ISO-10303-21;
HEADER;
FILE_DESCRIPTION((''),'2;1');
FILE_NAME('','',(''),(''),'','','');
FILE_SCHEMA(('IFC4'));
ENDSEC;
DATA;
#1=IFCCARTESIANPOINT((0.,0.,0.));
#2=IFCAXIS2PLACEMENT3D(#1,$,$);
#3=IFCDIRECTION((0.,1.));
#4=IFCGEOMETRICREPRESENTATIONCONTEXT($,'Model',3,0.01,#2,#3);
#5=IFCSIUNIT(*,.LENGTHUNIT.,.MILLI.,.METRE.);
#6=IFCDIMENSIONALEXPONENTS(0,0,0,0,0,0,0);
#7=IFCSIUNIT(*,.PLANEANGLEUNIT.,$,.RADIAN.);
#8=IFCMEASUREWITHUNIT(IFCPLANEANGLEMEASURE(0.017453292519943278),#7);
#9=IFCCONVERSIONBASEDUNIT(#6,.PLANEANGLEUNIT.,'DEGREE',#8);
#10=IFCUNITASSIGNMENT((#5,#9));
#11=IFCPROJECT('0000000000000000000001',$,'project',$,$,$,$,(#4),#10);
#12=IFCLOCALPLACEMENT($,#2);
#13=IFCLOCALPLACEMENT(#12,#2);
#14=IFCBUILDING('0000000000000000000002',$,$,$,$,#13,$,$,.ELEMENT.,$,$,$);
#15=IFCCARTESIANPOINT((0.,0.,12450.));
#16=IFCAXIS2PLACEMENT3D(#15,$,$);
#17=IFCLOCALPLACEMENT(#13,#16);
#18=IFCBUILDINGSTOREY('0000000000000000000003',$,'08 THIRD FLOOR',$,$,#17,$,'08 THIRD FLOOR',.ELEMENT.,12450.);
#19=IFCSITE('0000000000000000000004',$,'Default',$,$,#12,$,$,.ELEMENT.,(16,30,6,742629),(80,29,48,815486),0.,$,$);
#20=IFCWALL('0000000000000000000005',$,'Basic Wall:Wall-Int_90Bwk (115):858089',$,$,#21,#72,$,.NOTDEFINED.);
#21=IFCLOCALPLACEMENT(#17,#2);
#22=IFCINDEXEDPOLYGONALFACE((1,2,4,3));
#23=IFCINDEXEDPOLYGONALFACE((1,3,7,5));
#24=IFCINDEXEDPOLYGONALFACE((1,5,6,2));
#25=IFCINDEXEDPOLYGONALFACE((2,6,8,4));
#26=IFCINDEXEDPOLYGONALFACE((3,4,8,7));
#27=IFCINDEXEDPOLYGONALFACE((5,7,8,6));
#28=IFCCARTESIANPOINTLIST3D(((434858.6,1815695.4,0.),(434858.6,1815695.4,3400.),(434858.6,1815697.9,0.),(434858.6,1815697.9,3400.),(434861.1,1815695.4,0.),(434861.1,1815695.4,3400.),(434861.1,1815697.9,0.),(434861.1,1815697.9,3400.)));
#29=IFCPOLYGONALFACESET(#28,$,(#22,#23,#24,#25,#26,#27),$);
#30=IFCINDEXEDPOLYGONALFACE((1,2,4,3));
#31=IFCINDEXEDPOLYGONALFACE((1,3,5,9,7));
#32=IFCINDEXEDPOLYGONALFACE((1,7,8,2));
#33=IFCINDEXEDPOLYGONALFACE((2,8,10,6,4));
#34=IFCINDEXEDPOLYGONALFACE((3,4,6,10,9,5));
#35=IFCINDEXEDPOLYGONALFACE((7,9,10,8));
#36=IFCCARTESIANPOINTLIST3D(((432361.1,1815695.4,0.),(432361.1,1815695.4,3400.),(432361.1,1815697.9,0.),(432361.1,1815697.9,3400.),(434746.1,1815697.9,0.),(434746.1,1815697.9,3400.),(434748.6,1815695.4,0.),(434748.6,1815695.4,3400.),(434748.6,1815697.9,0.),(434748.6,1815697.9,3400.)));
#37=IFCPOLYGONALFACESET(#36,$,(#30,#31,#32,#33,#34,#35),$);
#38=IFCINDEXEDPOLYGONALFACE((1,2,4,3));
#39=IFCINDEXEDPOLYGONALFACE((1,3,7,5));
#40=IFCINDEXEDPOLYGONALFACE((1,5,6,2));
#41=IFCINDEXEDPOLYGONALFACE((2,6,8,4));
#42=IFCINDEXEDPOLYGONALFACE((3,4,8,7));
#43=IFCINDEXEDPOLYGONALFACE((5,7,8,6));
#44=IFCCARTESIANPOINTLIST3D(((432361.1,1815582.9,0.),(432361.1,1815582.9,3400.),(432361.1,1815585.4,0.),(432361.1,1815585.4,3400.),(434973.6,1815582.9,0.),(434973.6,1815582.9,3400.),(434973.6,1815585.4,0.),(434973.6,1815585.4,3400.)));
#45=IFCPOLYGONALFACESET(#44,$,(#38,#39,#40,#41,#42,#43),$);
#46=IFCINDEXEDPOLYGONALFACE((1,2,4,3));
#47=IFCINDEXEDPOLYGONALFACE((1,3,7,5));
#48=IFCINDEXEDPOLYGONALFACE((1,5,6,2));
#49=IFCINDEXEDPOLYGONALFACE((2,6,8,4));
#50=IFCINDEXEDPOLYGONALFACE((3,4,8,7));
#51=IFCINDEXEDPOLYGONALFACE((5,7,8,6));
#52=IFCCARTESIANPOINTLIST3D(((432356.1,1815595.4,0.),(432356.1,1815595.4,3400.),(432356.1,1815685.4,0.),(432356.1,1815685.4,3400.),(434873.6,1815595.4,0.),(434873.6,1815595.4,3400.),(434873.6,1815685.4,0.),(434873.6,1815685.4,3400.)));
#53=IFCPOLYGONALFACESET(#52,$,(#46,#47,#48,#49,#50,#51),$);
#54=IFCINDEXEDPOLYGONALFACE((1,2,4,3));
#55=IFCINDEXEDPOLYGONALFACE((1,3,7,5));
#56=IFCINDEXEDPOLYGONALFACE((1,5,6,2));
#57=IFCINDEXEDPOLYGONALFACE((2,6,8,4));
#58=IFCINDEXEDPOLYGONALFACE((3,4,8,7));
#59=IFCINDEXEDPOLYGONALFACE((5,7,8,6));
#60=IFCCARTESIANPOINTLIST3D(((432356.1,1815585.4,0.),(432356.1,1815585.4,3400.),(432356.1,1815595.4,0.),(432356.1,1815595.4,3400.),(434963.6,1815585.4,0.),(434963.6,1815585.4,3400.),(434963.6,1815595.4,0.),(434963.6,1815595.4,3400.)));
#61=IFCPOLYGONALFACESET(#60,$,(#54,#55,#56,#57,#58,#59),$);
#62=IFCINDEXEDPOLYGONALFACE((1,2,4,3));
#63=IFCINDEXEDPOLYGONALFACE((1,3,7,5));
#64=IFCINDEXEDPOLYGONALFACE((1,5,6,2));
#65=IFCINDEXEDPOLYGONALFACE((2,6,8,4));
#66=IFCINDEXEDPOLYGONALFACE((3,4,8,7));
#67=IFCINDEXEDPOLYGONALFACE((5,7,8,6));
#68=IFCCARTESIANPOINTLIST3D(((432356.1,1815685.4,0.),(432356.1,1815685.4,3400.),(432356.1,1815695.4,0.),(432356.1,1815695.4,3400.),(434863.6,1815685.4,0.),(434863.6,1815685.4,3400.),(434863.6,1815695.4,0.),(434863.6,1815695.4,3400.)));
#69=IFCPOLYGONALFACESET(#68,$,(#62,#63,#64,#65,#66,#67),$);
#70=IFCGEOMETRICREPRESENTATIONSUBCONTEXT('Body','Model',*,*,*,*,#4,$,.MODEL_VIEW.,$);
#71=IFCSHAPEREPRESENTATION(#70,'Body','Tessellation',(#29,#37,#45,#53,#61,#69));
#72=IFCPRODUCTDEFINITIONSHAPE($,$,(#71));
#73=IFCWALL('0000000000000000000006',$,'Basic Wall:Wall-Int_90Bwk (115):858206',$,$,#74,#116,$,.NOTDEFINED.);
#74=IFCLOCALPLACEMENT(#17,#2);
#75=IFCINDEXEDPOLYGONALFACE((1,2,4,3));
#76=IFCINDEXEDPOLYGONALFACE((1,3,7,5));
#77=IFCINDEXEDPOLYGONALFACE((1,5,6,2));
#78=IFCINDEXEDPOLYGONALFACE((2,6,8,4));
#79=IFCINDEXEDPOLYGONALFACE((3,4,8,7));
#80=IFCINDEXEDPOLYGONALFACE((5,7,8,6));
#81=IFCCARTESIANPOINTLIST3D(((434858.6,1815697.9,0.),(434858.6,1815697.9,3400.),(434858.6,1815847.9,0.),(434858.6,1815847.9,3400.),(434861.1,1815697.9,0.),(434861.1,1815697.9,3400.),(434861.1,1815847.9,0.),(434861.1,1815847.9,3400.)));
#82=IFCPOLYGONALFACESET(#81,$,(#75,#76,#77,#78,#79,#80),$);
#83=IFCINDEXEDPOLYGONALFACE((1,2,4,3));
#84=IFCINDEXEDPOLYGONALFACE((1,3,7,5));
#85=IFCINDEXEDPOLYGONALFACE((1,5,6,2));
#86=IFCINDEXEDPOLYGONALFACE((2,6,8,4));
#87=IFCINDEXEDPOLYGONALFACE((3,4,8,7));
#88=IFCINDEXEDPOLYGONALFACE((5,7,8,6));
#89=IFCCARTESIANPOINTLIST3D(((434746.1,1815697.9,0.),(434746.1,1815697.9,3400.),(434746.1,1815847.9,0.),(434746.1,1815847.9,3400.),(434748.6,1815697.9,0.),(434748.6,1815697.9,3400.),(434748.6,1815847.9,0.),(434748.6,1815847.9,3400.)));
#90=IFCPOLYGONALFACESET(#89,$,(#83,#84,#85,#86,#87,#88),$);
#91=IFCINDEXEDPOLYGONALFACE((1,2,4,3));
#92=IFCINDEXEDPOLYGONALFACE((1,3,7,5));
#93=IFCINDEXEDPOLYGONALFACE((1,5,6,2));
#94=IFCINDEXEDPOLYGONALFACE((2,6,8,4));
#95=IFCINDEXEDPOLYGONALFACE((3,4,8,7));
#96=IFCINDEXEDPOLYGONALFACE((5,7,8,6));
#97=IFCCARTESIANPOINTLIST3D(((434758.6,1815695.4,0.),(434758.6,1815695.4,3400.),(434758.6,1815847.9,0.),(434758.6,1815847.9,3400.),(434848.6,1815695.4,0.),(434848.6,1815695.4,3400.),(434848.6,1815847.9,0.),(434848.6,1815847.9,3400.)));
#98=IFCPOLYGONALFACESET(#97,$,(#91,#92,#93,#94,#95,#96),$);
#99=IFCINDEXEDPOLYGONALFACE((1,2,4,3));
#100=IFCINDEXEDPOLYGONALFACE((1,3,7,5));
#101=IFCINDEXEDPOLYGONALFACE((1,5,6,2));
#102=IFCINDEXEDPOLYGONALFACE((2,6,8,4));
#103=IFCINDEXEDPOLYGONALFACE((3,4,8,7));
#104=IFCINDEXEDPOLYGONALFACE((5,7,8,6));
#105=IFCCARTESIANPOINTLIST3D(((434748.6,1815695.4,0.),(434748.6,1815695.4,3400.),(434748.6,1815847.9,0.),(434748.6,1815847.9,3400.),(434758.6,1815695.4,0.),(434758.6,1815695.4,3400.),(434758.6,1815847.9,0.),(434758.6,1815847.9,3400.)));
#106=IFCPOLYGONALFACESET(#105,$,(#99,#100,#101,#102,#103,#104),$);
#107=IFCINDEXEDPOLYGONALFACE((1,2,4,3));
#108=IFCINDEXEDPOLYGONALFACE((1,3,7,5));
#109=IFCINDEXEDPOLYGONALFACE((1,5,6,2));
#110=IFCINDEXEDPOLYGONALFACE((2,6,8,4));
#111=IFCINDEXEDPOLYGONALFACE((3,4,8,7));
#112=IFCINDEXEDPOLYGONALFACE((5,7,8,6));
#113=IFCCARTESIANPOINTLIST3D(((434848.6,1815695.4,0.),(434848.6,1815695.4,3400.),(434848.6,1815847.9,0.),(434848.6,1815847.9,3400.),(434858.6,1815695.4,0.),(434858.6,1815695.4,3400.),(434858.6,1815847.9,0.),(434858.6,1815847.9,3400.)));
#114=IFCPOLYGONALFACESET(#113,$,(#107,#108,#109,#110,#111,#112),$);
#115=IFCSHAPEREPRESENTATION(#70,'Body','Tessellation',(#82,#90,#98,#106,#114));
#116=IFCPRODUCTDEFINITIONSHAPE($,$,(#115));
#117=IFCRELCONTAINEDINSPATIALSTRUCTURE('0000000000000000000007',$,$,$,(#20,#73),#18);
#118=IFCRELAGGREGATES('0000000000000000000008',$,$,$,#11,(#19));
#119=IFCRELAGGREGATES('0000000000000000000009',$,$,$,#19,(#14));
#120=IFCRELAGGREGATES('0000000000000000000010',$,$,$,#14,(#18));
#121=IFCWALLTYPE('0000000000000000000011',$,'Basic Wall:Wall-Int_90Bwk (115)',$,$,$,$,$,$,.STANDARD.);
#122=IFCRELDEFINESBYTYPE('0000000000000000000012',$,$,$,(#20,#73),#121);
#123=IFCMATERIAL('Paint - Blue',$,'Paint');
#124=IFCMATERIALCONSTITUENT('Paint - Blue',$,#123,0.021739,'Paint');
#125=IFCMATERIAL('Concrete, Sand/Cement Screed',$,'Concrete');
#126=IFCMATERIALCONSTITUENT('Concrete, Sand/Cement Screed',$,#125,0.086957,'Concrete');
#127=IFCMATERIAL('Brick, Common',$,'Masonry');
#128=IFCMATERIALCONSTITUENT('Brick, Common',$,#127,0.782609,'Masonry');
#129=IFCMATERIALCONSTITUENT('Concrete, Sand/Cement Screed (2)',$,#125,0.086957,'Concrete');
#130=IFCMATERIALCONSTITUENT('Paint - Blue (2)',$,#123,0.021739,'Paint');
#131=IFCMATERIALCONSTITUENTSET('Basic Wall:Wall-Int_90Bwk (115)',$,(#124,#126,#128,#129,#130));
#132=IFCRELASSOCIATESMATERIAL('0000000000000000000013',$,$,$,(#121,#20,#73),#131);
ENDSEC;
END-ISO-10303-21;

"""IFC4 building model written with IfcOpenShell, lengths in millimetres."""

from ifc_helpers import new_model, entity, si_unit, converted_unit, direction, frame, origin, place, context, subcontext, project, spatial, indexed_curve, outline, extrude, material, constituent, constituent_set, type_object, element, save


model = new_model("IFC4")

# Units and contexts
model_context = context("Model", 3, precision=0.01, world=origin(), true_north=direction((0.0, 1.0)))
body_context = subcontext(model_context, "Body", "Model", "MODEL_VIEW")
ifc_project = project(units=[si_unit("LENGTHUNIT", "METRE", prefix="MILLI"), converted_unit("PLANEANGLEUNIT", "DEGREE", entity("IfcPlaneAngleMeasure", 0.017453292519943278), si_unit("PLANEANGLEUNIT", "RADIAN"), dimensions=[0, 0, 0, 0, 0, 0, 0])], contexts=[model_context])

# Site, building, storey
site_placement = place(None, origin())
site = spatial("IfcSite", under=ifc_project, at=site_placement, Name="Default", CompositionType="ELEMENT", RefLatitude=(16, 30, 6, 742629), RefLongitude=(80, 29, 48, 815486), RefElevation=0.0)
building_placement = place(site_placement, origin())
building = spatial("IfcBuilding", under=site, at=building_placement, CompositionType="ELEMENT")
storey_placement = place(building_placement, frame((0.0, 0.0, 12450.0)))
storey = spatial("IfcBuildingStorey", under=building, at=storey_placement, Name="08 THIRD FLOOR", LongName="08 THIRD FLOOR", CompositionType="ELEMENT", Elevation=12450.0)

# Walls
ifc_material_1 = material(Name="Paint - Blue", Category="Paint")
ifc_constituent_1 = constituent(ifc_material_1, Name="Paint - Blue", Category="Paint", fraction=0.021739)
ifc_material_2 = material(Name="Concrete, Sand/Cement Screed", Category="Concrete")
ifc_constituent_2 = constituent(ifc_material_2, Name="Concrete, Sand/Cement Screed", Category="Concrete", fraction=0.086957)
ifc_material_3 = material(Name="Brick, Common", Category="Masonry")
ifc_constituent_3 = constituent(ifc_material_3, Name="Brick, Common", Category="Masonry", fraction=0.782609)
ifc_constituent_4 = constituent(ifc_material_2, Name="Concrete, Sand/Cement Screed (2)", Category="Concrete", fraction=0.086957)
ifc_constituent_5 = constituent(ifc_material_1, Name="Paint - Blue (2)", Category="Paint", fraction=0.021739)
ifc_constituent_set_1 = constituent_set(constituents=[ifc_constituent_1, ifc_constituent_2, ifc_constituent_3, ifc_constituent_4, ifc_constituent_5], Name="Basic Wall:Wall-Int_90Bwk (115)")
wall_type_1 = type_object("IfcWallType", Name="Basic Wall:Wall-Int_90Bwk (115)", PredefinedType="STANDARD", material=ifc_constituent_set_1)
wall_1_placement = place(storey_placement, frame((432361.1, 1815640.4, 0.0)))
element("IfcWall", 1, at=wall_1_placement, inside=storey, type_object=wall_type_1, material=ifc_constituent_set_1, Name="Basic Wall:Wall-Int_90Bwk (115):858089", PredefinedType="NOTDEFINED", context=body_context, shape_type="SweptSolid", body=[
    extrude(outline(indexed_curve([(-1.2, -1.3), (1.2, -1.3), (1.2, 1.3), (-1.2, 1.3), (-1.2, -1.3)], self_intersect=False)), frame((2498.7, 56.3, 0.0), z_axis=(0.0, 0.0, 1.0), x_axis=(-1.0, 0.0, 0.0)), (0.0, 0.0, 1.0), 3400.0),
    extrude(outline(indexed_curve([(-1432.0, -1.5), (955.5, -1.5), (955.5, 1.0), (953.0, 1.0), (-1432.0, 1.0), (-1432.0, -1.5)], self_intersect=False)), frame((1432.0, 56.5, 0.0)), (0.0, 0.0, 1.0), 3400.0),
    extrude(outline(indexed_curve([(-1.2, -1306.2), (1.3, -1306.2), (1.3, 1306.2), (-1.2, 1306.2), (-1.2, -1306.2)], self_intersect=False)), frame((1306.2, -56.3, 0.0), z_axis=(0.0, 0.0, 1.0), x_axis=(0.0, 1.0, 0.0)), (0.0, 0.0, 1.0), 3400.0),
    extrude(outline(indexed_curve([(-1258.7, -45.0), (1258.7, -45.0), (1258.7, 45.0), (-1258.7, 45.0), (-1258.7, -45.0)], self_intersect=False)), frame((1253.7, 0.0, 0.0)), (0.0, 0.0, 1.0), 3400.0),
    extrude(outline(indexed_curve([(-1303.7, -5.0), (1303.7, -5.0), (1303.7, 5.0), (-1303.7, 5.0), (-1303.7, -5.0)], self_intersect=False)), frame((1298.7, -50.0, 0.0)), (0.0, 0.0, 1.0), 3400.0),
    extrude(outline(indexed_curve([(-1253.7, -5.0), (1253.7, -5.0), (1253.7, 5.0), (-1253.7, 5.0), (-1253.7, -5.0)], self_intersect=False)), frame((1248.7, 50.0, 0.0)), (0.0, 0.0, 1.0), 3400.0),
])
wall_2_placement = place(storey_placement, frame((434803.6, 1815847.9, 0.0), z_axis=(0.0, 0.0, 1.0), x_axis=(0.0, -1.0, 0.0)))
element("IfcWall", 2, at=wall_2_placement, inside=storey, type_object=wall_type_1, material=ifc_constituent_set_1, Name="Basic Wall:Wall-Int_90Bwk (115):858206", PredefinedType="NOTDEFINED", context=body_context, shape_type="SweptSolid", body=[
    extrude(outline(indexed_curve([(-1.3, -75.0), (1.2, -75.0), (1.2, 75.0), (-1.3, 75.0), (-1.3, -75.0)], self_intersect=False)), frame((75.0, 56.2, 0.0), z_axis=(0.0, 0.0, 1.0), x_axis=(0.0, -1.0, 0.0)), (0.0, 0.0, 1.0), 3400.0),
    extrude(outline(indexed_curve([(-1.3, -75.0), (1.2, -75.0), (1.2, 75.0), (-1.3, 75.0), (-1.3, -75.0)], self_intersect=False)), frame((75.0, -56.2, 0.0), z_axis=(0.0, 0.0, 1.0), x_axis=(0.0, 1.0, 0.0)), (0.0, 0.0, 1.0), 3400.0),
    extrude(outline(indexed_curve([(-76.2, -45.0), (76.3, -45.0), (76.3, 45.0), (-76.2, 45.0), (-76.2, -45.0)], self_intersect=False)), frame((76.2, 0.0, 0.0)), (0.0, 0.0, 1.0), 3400.0),
    extrude(outline(indexed_curve([(-76.2, -5.0), (76.3, -5.0), (76.3, 5.0), (-76.2, 5.0), (-76.2, -5.0)], self_intersect=False)), frame((76.2, -50.0, 0.0)), (0.0, 0.0, 1.0), 3400.0),
    extrude(outline(indexed_curve([(-76.2, -5.0), (76.3, -5.0), (76.3, 5.0), (-76.2, 5.0), (-76.2, -5.0)], self_intersect=False)), frame((76.2, 50.0, 0.0)), (0.0, 0.0, 1.0), 3400.0),
])

save(model, "model.ifc")
